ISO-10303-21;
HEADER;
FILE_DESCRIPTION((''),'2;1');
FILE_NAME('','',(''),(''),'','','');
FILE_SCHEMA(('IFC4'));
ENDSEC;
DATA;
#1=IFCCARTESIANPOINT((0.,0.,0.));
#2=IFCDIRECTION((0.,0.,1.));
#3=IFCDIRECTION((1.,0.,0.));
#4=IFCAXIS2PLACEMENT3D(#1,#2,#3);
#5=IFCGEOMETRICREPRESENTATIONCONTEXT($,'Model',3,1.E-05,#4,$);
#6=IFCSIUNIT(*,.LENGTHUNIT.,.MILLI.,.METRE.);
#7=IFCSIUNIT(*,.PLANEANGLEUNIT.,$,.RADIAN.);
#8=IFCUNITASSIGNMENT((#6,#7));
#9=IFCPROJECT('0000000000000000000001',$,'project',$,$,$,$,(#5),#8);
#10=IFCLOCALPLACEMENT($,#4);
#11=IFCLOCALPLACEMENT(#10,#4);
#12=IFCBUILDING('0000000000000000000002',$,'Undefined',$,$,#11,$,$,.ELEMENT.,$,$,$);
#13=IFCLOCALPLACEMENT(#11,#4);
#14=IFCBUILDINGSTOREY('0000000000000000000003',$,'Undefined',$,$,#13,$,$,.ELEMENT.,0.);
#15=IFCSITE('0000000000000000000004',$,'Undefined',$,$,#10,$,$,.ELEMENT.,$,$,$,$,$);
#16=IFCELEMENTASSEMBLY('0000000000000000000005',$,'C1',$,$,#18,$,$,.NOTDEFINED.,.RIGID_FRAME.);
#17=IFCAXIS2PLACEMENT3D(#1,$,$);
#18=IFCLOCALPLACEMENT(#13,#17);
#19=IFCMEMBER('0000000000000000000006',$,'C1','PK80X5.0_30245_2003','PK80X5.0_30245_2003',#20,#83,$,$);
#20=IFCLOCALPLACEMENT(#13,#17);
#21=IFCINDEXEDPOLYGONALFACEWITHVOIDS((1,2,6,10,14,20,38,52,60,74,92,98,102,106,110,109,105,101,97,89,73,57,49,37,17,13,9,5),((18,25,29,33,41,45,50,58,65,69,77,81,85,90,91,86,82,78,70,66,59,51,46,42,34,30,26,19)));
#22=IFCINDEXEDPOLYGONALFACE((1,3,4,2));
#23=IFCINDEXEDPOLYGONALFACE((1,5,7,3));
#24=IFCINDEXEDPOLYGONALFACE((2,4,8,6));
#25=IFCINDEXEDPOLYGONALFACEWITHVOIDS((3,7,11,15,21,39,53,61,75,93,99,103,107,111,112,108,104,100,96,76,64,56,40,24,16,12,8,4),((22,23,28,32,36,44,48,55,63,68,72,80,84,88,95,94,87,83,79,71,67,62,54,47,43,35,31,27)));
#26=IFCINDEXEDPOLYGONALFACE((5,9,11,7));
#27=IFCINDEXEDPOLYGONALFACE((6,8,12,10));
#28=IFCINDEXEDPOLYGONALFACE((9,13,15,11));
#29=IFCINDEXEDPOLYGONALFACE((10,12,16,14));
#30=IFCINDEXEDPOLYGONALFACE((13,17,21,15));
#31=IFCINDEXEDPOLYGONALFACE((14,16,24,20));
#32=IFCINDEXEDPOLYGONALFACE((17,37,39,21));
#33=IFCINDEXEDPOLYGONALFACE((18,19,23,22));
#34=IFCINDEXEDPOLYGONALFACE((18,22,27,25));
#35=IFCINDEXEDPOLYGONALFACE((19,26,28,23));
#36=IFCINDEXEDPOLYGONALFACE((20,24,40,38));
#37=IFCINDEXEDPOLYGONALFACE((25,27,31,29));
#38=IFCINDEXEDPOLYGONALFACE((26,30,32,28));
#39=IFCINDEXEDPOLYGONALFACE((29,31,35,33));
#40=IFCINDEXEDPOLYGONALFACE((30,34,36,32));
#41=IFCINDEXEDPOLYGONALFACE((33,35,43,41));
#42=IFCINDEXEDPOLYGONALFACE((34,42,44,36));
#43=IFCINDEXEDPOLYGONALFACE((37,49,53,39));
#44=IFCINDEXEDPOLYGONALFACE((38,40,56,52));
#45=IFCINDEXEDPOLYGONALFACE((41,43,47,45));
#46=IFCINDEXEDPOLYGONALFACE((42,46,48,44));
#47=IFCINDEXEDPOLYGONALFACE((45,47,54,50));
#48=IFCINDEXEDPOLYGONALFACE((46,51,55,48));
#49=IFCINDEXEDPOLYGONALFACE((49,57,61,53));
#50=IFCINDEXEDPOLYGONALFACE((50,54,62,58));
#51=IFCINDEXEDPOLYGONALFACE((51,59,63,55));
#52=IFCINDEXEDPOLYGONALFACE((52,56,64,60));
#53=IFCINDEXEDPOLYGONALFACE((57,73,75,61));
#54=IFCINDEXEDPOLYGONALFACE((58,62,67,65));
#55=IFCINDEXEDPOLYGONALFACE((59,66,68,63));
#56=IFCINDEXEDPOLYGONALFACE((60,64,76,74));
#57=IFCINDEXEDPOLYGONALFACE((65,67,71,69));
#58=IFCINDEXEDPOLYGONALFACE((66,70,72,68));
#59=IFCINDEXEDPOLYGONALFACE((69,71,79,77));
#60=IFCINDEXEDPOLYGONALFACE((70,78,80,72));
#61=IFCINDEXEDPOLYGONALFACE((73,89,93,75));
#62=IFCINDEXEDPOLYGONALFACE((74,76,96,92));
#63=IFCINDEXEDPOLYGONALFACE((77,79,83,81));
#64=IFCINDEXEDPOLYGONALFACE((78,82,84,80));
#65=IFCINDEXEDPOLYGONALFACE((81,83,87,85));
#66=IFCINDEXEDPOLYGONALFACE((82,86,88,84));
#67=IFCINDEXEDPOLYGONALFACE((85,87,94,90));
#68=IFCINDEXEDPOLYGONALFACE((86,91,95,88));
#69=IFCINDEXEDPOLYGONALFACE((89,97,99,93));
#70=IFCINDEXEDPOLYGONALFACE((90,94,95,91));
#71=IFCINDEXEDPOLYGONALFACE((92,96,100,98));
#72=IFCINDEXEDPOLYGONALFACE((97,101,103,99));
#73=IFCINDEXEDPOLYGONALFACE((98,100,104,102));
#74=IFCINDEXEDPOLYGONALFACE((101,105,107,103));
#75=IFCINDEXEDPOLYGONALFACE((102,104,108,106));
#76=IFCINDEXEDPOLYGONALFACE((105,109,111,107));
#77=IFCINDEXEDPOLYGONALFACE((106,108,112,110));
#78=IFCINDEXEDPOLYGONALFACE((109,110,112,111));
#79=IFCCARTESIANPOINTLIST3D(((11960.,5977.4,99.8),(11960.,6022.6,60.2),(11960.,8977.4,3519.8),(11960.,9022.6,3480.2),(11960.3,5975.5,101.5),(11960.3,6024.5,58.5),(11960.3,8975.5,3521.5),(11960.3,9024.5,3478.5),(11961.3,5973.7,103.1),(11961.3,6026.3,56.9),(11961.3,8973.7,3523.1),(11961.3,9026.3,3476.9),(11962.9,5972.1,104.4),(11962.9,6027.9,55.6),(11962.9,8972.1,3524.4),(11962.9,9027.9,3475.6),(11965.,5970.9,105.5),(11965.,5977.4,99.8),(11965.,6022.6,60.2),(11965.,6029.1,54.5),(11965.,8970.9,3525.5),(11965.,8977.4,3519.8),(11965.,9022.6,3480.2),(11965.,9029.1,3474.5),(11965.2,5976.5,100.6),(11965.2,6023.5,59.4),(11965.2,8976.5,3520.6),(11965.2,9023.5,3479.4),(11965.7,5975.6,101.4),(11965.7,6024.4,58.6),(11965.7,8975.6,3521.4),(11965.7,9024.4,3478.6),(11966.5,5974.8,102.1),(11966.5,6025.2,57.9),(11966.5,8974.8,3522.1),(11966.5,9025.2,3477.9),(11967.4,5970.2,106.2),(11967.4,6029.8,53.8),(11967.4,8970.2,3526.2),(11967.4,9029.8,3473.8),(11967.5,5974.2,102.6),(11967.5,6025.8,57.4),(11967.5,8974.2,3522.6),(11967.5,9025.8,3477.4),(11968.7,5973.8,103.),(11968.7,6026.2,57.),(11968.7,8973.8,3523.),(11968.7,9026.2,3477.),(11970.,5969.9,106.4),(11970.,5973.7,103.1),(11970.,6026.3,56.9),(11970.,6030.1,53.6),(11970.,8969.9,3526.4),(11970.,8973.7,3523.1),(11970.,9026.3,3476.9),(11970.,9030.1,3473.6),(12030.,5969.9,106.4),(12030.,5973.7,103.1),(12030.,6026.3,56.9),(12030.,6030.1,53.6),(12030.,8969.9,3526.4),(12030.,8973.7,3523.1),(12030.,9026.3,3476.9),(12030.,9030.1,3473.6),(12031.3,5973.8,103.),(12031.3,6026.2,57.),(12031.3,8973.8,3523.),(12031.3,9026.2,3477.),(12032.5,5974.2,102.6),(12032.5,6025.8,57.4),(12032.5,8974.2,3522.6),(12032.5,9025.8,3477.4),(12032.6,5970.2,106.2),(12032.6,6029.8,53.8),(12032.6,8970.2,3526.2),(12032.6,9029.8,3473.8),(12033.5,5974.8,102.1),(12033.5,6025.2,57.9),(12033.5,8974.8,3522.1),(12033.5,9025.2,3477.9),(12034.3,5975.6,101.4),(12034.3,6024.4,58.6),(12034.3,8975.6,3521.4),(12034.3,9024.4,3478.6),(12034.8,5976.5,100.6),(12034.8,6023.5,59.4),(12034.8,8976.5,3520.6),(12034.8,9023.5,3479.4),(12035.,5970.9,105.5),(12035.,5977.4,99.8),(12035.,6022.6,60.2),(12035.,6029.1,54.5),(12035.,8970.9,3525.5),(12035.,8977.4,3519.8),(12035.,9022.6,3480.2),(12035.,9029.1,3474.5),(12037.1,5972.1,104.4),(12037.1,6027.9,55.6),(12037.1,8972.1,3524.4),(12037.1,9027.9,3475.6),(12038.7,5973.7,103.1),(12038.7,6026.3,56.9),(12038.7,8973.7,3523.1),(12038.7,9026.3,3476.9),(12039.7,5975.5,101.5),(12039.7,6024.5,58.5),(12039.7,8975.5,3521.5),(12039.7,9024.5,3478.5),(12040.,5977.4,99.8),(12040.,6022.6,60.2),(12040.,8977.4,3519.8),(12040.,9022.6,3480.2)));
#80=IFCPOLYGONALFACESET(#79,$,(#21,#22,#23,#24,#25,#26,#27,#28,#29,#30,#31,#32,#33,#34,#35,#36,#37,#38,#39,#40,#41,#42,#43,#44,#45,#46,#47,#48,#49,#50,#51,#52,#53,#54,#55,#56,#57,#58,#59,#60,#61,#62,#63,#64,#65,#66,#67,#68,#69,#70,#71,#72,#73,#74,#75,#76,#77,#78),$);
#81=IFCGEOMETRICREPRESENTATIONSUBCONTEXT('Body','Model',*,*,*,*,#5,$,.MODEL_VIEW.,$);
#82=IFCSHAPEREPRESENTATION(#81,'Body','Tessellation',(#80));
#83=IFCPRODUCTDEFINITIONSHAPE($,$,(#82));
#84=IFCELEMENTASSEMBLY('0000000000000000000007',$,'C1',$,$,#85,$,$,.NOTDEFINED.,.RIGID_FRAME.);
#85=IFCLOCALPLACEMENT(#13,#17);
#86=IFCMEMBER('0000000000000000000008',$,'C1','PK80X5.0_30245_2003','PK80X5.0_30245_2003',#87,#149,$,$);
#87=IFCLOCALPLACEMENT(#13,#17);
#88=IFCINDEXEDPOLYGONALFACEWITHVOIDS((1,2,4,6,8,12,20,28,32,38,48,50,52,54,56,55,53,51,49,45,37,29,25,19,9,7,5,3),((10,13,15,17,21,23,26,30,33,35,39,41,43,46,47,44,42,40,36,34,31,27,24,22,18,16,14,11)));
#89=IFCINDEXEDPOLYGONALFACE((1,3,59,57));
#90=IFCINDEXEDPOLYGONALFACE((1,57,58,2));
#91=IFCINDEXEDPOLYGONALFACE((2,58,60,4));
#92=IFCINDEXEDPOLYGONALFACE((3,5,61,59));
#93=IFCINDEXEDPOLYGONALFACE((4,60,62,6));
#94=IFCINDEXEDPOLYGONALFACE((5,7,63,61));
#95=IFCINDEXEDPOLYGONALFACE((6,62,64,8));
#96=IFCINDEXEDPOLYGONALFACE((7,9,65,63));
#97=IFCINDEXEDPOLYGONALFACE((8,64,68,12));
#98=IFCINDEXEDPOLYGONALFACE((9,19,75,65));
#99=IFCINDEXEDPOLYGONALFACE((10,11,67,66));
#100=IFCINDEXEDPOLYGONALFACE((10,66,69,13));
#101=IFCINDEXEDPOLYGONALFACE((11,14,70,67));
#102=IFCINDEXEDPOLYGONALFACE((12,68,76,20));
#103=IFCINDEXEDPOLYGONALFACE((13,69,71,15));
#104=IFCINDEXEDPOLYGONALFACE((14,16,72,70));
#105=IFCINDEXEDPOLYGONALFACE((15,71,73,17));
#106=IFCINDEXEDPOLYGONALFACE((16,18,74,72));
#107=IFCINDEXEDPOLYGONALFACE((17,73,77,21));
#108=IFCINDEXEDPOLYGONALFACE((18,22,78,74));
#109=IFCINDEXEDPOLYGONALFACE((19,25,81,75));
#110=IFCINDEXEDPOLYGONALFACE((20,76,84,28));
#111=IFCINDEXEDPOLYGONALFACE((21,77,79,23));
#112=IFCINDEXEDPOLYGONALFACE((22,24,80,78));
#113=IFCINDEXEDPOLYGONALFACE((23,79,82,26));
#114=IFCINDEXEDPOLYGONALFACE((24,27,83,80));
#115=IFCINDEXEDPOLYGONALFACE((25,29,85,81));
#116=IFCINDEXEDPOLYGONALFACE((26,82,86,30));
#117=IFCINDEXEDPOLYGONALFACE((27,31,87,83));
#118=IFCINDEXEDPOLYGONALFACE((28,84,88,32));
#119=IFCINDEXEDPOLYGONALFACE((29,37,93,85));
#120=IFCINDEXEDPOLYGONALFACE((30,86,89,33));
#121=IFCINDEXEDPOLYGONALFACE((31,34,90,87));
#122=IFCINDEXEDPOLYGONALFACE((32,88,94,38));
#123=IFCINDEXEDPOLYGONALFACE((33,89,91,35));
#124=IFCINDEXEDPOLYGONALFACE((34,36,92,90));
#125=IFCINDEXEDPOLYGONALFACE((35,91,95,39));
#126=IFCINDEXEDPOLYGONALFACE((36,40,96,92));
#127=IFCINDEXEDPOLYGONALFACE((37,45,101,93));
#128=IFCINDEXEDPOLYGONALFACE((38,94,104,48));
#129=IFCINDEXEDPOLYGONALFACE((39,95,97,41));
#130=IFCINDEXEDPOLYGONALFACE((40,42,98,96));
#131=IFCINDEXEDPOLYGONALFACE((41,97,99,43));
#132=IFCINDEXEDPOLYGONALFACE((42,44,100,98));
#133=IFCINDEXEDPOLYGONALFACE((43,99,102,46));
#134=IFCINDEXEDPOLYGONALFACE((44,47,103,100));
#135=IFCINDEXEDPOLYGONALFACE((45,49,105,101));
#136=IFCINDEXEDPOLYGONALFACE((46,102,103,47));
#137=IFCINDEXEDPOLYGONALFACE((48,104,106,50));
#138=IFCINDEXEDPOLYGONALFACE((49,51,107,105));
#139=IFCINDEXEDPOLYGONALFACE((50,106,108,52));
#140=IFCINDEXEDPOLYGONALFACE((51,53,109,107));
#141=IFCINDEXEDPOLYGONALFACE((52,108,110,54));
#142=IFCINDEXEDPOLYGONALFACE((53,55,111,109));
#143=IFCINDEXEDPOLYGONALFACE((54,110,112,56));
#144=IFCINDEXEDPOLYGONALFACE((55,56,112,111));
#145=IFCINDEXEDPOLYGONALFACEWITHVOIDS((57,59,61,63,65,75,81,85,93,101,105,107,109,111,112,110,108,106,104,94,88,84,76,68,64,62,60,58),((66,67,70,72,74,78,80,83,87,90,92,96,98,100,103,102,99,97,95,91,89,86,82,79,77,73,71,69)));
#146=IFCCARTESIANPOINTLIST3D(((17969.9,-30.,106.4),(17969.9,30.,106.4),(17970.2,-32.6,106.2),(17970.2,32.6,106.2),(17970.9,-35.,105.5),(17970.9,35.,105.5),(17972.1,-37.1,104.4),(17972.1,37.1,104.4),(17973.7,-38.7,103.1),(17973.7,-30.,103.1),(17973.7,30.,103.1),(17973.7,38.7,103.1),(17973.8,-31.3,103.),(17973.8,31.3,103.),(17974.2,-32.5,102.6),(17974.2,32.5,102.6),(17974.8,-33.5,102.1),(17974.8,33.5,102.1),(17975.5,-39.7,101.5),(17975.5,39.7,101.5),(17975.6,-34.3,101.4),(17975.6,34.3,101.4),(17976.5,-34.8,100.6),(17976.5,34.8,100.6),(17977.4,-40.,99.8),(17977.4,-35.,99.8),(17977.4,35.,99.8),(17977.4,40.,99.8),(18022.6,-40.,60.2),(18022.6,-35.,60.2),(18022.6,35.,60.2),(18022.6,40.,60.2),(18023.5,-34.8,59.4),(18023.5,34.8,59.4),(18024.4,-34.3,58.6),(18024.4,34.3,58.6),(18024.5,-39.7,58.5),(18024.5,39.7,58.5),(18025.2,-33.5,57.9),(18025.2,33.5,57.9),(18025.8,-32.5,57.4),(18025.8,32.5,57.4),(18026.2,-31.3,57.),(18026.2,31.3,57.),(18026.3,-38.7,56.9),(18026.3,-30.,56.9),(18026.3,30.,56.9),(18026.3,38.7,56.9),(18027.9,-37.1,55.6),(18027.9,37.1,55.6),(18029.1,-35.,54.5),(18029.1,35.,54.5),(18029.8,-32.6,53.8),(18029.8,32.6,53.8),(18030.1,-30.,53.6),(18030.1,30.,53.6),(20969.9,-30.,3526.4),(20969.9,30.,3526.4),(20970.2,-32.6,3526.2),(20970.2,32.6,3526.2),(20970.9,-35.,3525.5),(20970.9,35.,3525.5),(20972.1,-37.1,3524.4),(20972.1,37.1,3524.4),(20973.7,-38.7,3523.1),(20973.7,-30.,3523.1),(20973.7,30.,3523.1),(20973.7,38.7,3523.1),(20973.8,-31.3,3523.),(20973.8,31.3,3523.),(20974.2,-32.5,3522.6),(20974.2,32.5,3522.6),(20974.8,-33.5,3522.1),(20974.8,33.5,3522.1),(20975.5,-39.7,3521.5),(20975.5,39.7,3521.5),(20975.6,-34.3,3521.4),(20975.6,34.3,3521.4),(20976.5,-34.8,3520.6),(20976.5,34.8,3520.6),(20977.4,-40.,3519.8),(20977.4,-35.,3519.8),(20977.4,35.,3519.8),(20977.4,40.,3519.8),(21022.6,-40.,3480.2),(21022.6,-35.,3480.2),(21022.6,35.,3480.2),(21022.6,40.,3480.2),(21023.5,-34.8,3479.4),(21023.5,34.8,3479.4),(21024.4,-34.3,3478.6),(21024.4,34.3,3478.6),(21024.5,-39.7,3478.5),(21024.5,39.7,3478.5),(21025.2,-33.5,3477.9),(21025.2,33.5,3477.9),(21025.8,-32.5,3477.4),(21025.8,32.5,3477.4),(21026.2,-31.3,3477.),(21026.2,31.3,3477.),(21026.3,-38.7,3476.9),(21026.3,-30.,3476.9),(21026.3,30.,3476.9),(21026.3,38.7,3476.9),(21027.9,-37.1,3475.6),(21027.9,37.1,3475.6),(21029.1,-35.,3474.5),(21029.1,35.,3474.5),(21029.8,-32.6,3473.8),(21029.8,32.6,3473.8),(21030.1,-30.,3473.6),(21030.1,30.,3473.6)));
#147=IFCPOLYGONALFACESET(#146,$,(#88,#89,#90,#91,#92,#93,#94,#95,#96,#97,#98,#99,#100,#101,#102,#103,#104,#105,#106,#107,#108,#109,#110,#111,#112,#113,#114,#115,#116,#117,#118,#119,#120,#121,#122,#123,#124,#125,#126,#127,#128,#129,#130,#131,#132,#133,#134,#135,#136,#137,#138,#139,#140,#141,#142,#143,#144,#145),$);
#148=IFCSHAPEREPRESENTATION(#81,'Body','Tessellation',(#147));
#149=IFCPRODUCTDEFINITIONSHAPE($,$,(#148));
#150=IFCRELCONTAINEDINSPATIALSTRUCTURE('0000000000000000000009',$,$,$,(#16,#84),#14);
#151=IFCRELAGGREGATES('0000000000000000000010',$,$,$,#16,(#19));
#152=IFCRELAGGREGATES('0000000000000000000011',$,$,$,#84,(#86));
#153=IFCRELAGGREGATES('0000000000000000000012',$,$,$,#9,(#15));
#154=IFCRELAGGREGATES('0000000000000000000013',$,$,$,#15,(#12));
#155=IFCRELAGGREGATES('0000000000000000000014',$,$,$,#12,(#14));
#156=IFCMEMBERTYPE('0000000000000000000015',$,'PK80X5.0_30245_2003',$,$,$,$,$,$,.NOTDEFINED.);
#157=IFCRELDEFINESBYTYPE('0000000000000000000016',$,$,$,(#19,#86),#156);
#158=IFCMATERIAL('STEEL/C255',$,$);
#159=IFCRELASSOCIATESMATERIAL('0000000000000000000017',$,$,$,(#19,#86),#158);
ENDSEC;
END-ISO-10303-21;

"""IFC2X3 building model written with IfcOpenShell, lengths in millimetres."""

from ifc_helpers import new_model, si_unit, frame, origin_with_axes, origin_2d_with_axis, place, context, subcontext, project, spatial, hollow_rectangle, extrude, material, type_object, element, aggregate, save


model = new_model("IFC2X3")

# Units and contexts
model_context = context("Model", 3, precision=1e-05, world=origin_with_axes())
body_context = subcontext(model_context, "Body", "Model", "MODEL_VIEW")
ifc_project = project(units=[si_unit("LENGTHUNIT", "METRE", prefix="MILLI"), si_unit("PLANEANGLEUNIT", "RADIAN")], contexts=[model_context])

# Site, building, storey
site_placement = place(None, origin_with_axes())
site = spatial("IfcSite", under=ifc_project, at=site_placement, Name="Undefined", CompositionType="ELEMENT")
building_placement = place(site_placement, origin_with_axes())
building = spatial("IfcBuilding", under=site, at=building_placement, Name="Undefined", CompositionType="ELEMENT")
storey_placement = place(building_placement, origin_with_axes())
storey = spatial("IfcBuildingStorey", under=building, at=storey_placement, Name="Undefined", CompositionType="ELEMENT", Elevation=0.0)

# Shared definitions
ifc_material_1 = material(Name="STEEL/C255")

# Element assemblies, members
assembly_1_placement = place(storey_placement, origin_with_axes())
assembly_1 = element("IfcElementAssembly", 1, at=assembly_1_placement, inside=storey, Name="C1", AssemblyPlace="NOTDEFINED", PredefinedType="RIGID_FRAME")
member_type = type_object("IfcMemberType", Name="PK80X5.0_30245_2003", PredefinedType="NOTDEFINED")
member_1_placement = place(assembly_1_placement, frame((12000.0, 6000.0, 80.0), z_axis=(0.0, 0.751759, -0.659438), x_axis=(0.0, 0.659438, 0.751759)))
member_1 = element("IfcMember", 2, at=member_1_placement, type_object=member_type, material=ifc_material_1, Name="C1", Description="PK80X5.0_30245_2003", ObjectType="PK80X5.0_30245_2003", context=body_context, shape_type="SweptSolid", body=[
    extrude(hollow_rectangle(XDim=80.0, YDim=80.0, WallThickness=5.0, InnerFilletRadius=5.0, OuterFilletRadius=10.0, at=origin_2d_with_axis()), frame((4549.3, 0.0, 0.0), z_axis=(-1.0, 0.0, 0.0), x_axis=(0.0, -1.0, 0.0)), (0.0, 0.0, 1.0), 4549.3),
])
aggregate(assembly_1, [member_1])
assembly_2_placement = place(storey_placement, origin_with_axes())
assembly_2 = element("IfcElementAssembly", 3, at=assembly_2_placement, inside=storey, Name="C1", AssemblyPlace="NOTDEFINED", PredefinedType="RIGID_FRAME")
member_2_placement = place(assembly_2_placement, frame((18000.0, 0.0, 80.0), z_axis=(0.751759, 0.0, -0.659438), x_axis=(0.659438, 0.0, 0.751759)))
member_2 = element("IfcMember", 4, at=member_2_placement, type_object=member_type, material=ifc_material_1, Name="C1", Description="PK80X5.0_30245_2003", ObjectType="PK80X5.0_30245_2003", context=body_context, shape_type="SweptSolid", body=[
    extrude(hollow_rectangle(XDim=80.0, YDim=80.0, WallThickness=5.0, InnerFilletRadius=5.0, OuterFilletRadius=10.0, at=origin_2d_with_axis()), frame((4549.3, 0.0, 0.0), z_axis=(-1.0, 0.0, 0.0), x_axis=(0.0, -1.0, 0.0)), (0.0, 0.0, 1.0), 4549.3),
])
aggregate(assembly_2, [member_2])

save(model, "model.ifc")
